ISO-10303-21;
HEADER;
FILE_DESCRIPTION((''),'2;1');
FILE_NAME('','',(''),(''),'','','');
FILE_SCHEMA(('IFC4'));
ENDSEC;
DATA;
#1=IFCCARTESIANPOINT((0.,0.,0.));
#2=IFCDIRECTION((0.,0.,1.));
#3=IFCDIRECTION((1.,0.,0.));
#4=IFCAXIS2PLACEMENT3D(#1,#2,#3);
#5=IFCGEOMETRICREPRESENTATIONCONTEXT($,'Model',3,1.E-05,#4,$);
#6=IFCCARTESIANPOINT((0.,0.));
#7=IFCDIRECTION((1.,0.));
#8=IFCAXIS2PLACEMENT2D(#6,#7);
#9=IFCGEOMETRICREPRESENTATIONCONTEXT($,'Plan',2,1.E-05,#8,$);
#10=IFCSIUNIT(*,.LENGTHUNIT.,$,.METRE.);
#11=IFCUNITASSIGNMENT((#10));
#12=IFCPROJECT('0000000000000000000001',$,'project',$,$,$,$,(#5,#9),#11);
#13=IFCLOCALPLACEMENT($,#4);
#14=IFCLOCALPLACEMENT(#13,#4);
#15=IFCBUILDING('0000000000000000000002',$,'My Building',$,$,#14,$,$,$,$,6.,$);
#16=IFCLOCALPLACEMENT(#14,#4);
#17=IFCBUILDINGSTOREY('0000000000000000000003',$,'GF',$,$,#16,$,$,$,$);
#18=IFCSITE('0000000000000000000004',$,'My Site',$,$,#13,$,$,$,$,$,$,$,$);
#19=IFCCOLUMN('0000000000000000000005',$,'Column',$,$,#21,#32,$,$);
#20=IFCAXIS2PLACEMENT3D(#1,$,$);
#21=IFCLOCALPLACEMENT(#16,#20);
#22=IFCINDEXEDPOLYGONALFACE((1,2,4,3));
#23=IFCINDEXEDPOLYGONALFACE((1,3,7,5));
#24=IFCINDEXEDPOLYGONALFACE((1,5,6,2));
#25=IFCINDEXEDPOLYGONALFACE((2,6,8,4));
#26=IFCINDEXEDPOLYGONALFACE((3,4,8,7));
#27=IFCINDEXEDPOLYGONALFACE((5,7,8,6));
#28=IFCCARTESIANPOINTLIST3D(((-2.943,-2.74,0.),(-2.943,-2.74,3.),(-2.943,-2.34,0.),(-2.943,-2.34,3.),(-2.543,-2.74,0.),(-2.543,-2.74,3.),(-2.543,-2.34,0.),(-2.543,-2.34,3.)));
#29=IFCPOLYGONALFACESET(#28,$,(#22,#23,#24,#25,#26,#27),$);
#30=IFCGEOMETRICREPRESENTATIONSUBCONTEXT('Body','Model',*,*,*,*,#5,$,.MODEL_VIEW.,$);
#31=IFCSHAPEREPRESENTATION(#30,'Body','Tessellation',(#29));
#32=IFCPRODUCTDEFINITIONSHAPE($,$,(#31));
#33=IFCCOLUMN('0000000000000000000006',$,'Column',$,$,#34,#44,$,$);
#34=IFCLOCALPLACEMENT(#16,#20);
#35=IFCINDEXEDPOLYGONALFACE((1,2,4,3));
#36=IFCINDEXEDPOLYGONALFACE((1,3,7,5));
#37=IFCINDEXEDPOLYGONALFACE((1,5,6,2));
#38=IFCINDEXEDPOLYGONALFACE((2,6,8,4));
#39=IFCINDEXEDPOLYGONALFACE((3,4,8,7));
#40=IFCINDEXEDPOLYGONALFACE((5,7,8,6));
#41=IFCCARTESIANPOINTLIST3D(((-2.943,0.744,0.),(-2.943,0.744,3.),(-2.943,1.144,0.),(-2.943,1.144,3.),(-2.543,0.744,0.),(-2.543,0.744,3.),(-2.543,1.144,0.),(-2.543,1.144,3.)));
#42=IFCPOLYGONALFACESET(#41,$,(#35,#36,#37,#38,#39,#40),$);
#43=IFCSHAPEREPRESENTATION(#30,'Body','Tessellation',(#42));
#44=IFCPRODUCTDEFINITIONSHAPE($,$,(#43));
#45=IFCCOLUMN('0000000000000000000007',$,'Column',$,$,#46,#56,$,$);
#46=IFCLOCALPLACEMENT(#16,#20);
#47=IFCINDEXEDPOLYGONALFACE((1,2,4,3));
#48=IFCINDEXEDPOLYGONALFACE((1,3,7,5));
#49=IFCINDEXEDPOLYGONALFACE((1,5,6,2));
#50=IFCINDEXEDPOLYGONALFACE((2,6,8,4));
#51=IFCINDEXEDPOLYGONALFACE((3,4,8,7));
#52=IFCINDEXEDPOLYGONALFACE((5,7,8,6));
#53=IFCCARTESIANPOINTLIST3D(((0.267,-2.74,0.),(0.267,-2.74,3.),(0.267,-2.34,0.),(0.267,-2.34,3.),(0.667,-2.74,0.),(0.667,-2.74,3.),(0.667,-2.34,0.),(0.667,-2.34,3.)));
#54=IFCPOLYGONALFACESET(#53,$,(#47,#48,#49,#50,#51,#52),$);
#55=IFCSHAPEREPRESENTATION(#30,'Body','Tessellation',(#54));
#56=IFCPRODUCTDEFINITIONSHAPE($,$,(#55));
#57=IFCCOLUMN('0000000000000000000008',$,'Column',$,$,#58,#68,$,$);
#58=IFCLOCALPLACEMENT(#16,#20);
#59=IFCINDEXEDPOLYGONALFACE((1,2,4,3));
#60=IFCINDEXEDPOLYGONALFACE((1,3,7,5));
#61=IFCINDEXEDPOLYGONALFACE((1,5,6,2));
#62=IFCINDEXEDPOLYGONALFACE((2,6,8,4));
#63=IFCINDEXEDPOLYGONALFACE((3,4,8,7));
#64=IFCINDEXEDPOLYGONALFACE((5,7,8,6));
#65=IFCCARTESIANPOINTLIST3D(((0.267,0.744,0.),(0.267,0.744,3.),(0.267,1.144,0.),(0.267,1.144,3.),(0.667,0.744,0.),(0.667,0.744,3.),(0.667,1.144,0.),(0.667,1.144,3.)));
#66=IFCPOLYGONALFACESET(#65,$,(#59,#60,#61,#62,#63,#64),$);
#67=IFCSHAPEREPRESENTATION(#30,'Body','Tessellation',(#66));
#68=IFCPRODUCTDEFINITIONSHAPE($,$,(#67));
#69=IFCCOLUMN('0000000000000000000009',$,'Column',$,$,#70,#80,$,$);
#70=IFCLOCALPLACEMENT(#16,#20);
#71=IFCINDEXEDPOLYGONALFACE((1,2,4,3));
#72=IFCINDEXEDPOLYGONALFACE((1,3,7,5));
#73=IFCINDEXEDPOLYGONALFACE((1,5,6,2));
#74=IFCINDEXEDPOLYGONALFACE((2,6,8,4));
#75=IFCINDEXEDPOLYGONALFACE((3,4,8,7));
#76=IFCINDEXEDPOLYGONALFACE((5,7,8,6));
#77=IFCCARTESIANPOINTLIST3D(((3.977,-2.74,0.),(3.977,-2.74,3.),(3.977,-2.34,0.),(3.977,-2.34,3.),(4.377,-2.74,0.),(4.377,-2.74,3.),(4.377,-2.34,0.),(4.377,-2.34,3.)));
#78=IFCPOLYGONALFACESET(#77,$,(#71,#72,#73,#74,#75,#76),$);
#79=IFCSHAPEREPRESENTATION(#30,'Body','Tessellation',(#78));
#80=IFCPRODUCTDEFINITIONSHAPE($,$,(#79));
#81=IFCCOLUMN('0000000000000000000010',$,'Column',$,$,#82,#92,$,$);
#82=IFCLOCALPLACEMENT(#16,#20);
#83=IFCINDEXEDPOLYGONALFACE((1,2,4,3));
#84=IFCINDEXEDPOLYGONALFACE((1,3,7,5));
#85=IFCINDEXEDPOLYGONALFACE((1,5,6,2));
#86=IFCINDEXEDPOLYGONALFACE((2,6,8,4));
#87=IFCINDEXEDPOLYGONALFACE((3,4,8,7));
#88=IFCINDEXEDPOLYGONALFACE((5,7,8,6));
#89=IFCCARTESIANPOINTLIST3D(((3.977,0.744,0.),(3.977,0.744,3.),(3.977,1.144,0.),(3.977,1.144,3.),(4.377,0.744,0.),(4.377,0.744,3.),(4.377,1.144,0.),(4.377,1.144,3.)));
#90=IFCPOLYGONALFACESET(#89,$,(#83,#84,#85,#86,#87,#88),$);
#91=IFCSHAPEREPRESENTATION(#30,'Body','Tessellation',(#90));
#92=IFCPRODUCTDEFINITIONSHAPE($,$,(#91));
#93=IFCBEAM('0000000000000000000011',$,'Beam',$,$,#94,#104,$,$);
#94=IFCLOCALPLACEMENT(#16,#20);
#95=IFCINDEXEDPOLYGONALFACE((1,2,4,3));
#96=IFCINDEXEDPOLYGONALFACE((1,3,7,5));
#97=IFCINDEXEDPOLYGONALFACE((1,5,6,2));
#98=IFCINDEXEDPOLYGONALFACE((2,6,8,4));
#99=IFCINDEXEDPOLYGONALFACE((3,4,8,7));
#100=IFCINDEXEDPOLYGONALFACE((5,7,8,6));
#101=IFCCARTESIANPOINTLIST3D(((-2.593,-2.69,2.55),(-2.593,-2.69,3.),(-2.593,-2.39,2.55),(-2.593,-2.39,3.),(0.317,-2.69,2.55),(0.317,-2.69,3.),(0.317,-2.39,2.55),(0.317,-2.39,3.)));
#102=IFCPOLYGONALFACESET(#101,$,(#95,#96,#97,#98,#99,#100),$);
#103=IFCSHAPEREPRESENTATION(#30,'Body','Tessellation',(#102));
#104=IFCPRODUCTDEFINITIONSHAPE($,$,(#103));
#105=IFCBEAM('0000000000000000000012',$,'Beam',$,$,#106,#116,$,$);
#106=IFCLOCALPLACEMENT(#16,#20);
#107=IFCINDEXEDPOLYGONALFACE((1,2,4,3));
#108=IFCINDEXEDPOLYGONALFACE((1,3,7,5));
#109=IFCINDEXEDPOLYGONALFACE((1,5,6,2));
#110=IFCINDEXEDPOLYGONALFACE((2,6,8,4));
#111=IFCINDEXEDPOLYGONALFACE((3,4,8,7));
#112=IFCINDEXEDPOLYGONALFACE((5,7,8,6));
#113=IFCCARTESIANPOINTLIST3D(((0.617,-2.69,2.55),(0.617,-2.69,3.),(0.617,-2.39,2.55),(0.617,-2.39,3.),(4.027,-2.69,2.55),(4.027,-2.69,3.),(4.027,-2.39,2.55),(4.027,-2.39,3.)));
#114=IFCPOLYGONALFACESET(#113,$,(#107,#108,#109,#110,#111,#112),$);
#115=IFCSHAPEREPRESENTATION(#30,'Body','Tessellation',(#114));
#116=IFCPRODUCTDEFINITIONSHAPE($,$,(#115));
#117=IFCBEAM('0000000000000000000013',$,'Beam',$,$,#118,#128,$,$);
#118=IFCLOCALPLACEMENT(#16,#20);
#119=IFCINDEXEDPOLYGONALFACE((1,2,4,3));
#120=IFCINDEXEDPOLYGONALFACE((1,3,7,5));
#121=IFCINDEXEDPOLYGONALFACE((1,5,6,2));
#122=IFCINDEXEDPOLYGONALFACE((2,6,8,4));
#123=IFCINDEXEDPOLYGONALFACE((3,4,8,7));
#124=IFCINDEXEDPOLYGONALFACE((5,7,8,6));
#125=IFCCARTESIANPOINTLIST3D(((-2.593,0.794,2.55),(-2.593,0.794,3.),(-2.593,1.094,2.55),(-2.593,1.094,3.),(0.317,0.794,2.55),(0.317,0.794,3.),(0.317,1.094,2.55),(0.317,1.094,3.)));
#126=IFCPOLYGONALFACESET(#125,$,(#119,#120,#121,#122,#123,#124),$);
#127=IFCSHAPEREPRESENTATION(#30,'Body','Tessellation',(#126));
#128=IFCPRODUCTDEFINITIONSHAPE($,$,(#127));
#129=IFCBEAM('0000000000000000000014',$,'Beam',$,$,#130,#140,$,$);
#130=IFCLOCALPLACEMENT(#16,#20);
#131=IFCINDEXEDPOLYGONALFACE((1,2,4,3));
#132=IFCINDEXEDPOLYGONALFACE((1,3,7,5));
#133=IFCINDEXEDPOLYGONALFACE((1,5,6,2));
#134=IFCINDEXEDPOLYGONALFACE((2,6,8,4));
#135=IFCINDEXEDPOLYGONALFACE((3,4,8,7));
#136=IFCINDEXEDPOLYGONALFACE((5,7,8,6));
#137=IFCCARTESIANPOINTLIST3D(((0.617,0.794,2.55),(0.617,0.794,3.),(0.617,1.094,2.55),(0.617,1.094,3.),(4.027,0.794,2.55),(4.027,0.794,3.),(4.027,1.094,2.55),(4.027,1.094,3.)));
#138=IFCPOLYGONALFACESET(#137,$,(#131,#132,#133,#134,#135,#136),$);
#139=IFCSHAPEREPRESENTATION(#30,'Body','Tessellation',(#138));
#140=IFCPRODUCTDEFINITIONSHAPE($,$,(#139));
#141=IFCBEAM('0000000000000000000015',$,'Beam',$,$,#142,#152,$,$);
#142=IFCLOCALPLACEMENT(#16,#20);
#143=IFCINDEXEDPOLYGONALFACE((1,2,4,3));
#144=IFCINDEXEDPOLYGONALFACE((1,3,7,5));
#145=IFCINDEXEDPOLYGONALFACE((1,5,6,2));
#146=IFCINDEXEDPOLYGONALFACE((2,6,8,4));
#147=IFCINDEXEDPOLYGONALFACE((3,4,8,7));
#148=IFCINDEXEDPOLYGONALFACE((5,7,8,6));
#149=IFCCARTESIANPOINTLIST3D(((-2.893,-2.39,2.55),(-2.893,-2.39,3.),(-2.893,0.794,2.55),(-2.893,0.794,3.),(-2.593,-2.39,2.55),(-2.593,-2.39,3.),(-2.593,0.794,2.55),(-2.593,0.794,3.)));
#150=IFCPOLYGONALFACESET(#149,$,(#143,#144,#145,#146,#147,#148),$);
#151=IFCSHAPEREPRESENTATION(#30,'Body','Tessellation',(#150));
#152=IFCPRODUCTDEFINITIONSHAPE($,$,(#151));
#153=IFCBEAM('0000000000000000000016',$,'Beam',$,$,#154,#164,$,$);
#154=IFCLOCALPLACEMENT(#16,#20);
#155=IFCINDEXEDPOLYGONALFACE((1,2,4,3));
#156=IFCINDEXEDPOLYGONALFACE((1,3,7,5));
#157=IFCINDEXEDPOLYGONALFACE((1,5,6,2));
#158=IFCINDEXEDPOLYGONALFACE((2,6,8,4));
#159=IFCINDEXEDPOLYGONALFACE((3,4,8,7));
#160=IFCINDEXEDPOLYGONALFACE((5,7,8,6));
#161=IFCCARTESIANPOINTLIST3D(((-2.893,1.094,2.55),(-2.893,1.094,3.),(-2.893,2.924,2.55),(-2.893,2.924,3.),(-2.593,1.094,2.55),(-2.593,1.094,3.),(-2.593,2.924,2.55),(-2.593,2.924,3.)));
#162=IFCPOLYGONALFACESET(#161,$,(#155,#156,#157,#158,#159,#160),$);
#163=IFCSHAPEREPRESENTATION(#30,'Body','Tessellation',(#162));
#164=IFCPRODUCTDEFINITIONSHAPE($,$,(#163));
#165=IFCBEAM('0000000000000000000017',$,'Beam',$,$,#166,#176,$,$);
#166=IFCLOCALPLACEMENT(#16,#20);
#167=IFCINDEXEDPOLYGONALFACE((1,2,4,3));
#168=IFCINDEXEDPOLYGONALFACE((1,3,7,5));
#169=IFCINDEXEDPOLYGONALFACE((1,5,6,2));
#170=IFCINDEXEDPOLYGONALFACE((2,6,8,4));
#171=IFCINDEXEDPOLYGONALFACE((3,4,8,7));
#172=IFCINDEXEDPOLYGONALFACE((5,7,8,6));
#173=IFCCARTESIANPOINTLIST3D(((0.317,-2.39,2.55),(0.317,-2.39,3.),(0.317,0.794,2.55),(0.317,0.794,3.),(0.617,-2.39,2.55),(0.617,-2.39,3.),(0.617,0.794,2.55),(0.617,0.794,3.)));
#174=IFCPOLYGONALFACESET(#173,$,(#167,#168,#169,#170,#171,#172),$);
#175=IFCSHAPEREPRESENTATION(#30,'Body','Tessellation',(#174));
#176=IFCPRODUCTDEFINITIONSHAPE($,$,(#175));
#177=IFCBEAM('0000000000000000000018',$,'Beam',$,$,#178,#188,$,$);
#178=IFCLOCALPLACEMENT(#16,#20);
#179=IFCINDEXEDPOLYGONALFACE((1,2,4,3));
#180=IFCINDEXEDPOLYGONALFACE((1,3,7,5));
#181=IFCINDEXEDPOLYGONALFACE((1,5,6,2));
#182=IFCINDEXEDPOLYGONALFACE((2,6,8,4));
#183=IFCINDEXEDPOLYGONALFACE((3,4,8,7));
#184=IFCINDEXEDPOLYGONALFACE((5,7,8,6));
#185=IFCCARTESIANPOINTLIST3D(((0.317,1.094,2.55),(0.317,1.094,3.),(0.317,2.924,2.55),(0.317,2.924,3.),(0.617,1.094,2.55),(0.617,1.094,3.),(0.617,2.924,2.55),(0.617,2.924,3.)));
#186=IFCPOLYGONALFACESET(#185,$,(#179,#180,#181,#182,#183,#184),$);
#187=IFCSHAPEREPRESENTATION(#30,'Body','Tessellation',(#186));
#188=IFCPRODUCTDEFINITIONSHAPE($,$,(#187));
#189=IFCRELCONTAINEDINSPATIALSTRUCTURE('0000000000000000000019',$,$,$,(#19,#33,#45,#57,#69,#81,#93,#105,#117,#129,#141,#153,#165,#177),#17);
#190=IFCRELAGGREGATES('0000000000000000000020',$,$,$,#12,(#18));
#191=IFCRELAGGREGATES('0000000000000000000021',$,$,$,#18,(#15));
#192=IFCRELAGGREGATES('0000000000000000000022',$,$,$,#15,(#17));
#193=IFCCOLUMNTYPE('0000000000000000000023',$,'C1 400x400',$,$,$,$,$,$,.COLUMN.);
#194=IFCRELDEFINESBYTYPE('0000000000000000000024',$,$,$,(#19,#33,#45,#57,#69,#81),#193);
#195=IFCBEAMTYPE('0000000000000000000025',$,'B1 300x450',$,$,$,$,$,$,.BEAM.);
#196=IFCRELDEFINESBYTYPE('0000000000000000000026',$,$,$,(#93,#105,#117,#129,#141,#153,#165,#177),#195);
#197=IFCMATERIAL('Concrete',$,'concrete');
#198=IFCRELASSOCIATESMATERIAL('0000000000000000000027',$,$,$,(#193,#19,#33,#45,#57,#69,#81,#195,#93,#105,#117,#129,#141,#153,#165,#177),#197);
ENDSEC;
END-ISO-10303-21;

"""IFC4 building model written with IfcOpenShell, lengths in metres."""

from ifc_helpers import new_model, si_unit, frame, origin_with_axes, origin_2d_with_axis, place, context, subcontext, project, spatial, rectangle, extrude, material, material_profile, profile_set, profile_usage, type_object, element, save


model = new_model("IFC4")

# Units and contexts
model_context = context("Model", 3, precision=1e-05, world=origin_with_axes())
plan_context = context("Plan", 2, precision=1e-05, world=origin_2d_with_axis())
body_context_1 = subcontext(model_context, "Body", "Model", "MODEL_VIEW")
ifc_project = project(units=[si_unit("LENGTHUNIT", "METRE")], contexts=[model_context, plan_context])

# Site, building, storey
site_placement = place(None, origin_with_axes())
site = spatial("IfcSite", under=ifc_project, at=site_placement, Name="My Site")
building_placement = place(site_placement, origin_with_axes())
building = spatial("IfcBuilding", under=site, at=building_placement, Name="My Building", ElevationOfTerrain=6.0)
storey_placement = place(building_placement, origin_with_axes())
storey = spatial("IfcBuildingStorey", under=building, at=storey_placement, Name="GF")

# Columns
ifc_material_1 = material(Name="Concrete", Category="concrete")
ifc_material_profile_1 = material_profile(ifc_material_1, rectangle(XDim=0.4, YDim=0.4))
ifc_profile_set_1 = profile_set([ifc_material_profile_1], Name="C1 400x400")
ifc_profile_usage_1 = profile_usage(ifc_profile_set_1, cardinal=5)
column_type = type_object("IfcColumnType", Name="C1 400x400", PredefinedType="COLUMN", material=ifc_profile_set_1)
column_1_placement = place(storey_placement, frame((-2.743, -2.54, 0.0), z_axis=(0.0, 0.0, 1.0), x_axis=(1.0, 0.0, 0.0)))
element("IfcColumn", 1, at=column_1_placement, inside=storey, type_object=column_type, material=ifc_profile_usage_1, Name="Column", context=body_context_1, shape_type="SweptSolid", body=[
    extrude(rectangle(XDim=0.4, YDim=0.4), origin_with_axes(), (0.0, 0.0, 1.0), 3.0),
])
ifc_profile_usage_2 = profile_usage(ifc_profile_set_1, cardinal=5)
column_2_placement = place(storey_placement, frame((-2.743, 0.944, 0.0), z_axis=(0.0, 0.0, 1.0), x_axis=(1.0, 0.0, 0.0)))
element("IfcColumn", 2, at=column_2_placement, inside=storey, type_object=column_type, material=ifc_profile_usage_2, Name="Column", context=body_context_1, shape_type="SweptSolid", body=[
    extrude(rectangle(XDim=0.4, YDim=0.4), origin_with_axes(), (0.0, 0.0, 1.0), 3.0),
])
ifc_profile_usage_3 = profile_usage(ifc_profile_set_1, cardinal=5)
column_3_placement = place(storey_placement, frame((0.467, -2.54, 0.0), z_axis=(0.0, 0.0, 1.0), x_axis=(1.0, 0.0, 0.0)))
element("IfcColumn", 3, at=column_3_placement, inside=storey, type_object=column_type, material=ifc_profile_usage_3, Name="Column", context=body_context_1, shape_type="SweptSolid", body=[
    extrude(rectangle(XDim=0.4, YDim=0.4), origin_with_axes(), (0.0, 0.0, 1.0), 3.0),
])
ifc_profile_usage_4 = profile_usage(ifc_profile_set_1, cardinal=5)
column_4_placement = place(storey_placement, frame((0.467, 0.944, 0.0), z_axis=(0.0, 0.0, 1.0), x_axis=(1.0, 0.0, 0.0)))
element("IfcColumn", 4, at=column_4_placement, inside=storey, type_object=column_type, material=ifc_profile_usage_4, Name="Column", context=body_context_1, shape_type="SweptSolid", body=[
    extrude(rectangle(XDim=0.4, YDim=0.4), origin_with_axes(), (0.0, 0.0, 1.0), 3.0),
])
ifc_profile_usage_5 = profile_usage(ifc_profile_set_1, cardinal=5)
column_5_placement = place(storey_placement, frame((4.177, -2.54, 0.0), z_axis=(0.0, 0.0, 1.0), x_axis=(1.0, 0.0, 0.0)))
element("IfcColumn", 5, at=column_5_placement, inside=storey, type_object=column_type, material=ifc_profile_usage_5, Name="Column", context=body_context_1, shape_type="SweptSolid", body=[
    extrude(rectangle(XDim=0.4, YDim=0.4), origin_with_axes(), (0.0, 0.0, 1.0), 3.0),
])
ifc_profile_usage_6 = profile_usage(ifc_profile_set_1, cardinal=5)
column_6_placement = place(storey_placement, frame((4.177, 0.944, 0.0), z_axis=(0.0, 0.0, 1.0), x_axis=(1.0, 0.0, 0.0)))
element("IfcColumn", 6, at=column_6_placement, inside=storey, type_object=column_type, material=ifc_profile_usage_6, Name="Column", context=body_context_1, shape_type="SweptSolid", body=[
    extrude(rectangle(XDim=0.4, YDim=0.4), origin_with_axes(), (0.0, 0.0, 1.0), 3.0),
])

# Beams
ifc_material_profile_2 = material_profile(ifc_material_1, rectangle(XDim=0.3, YDim=0.45))
ifc_profile_set_2 = profile_set([ifc_material_profile_2], Name="B1 300x450")
ifc_profile_usage_7 = profile_usage(ifc_profile_set_2, cardinal=8)
beam_type = type_object("IfcBeamType", Name="B1 300x450", PredefinedType="BEAM", material=ifc_profile_set_2)
beam_1_placement = place(storey_placement, frame((-2.593, -2.54, 2.975), z_axis=(1.0, 0.0, 0.0), x_axis=(0.0, 1.0, 0.0)))
element("IfcBeam", 7, at=beam_1_placement, inside=storey, type_object=beam_type, material=ifc_profile_usage_7, Name="Beam", context=body_context_1, shape_type="SweptSolid", body=[
    extrude(rectangle(XDim=0.3, YDim=0.45), frame((0.0, -0.2, 0.0), z_axis=(0.0, 0.0, 1.0), x_axis=(1.0, 0.0, 0.0)), (0.0, 0.0, 1.0), 2.91),
])
ifc_profile_usage_8 = profile_usage(ifc_profile_set_2, cardinal=8)
beam_2_placement = place(storey_placement, frame((0.617, -2.54, 2.975), z_axis=(1.0, 0.0, 0.0), x_axis=(0.0, 1.0, 0.0)))
element("IfcBeam", 8, at=beam_2_placement, inside=storey, type_object=beam_type, material=ifc_profile_usage_8, Name="Beam", context=body_context_1, shape_type="SweptSolid", body=[
    extrude(rectangle(XDim=0.3, YDim=0.45), frame((0.0, -0.2, 0.0), z_axis=(0.0, 0.0, 1.0), x_axis=(1.0, 0.0, 0.0)), (0.0, 0.0, 1.0), 3.41),
])
ifc_profile_usage_9 = profile_usage(ifc_profile_set_2, cardinal=8)
beam_3_placement = place(storey_placement, frame((-2.593, 0.944, 2.975), z_axis=(1.0, 0.0, 0.0), x_axis=(0.0, 1.0, 0.0)))
element("IfcBeam", 9, at=beam_3_placement, inside=storey, type_object=beam_type, material=ifc_profile_usage_9, Name="Beam", context=body_context_1, shape_type="SweptSolid", body=[
    extrude(rectangle(XDim=0.3, YDim=0.45), frame((0.0, -0.2, 0.0), z_axis=(0.0, 0.0, 1.0), x_axis=(1.0, 0.0, 0.0)), (0.0, 0.0, 1.0), 2.91),
])
ifc_profile_usage_10 = profile_usage(ifc_profile_set_2, cardinal=8)
beam_4_placement = place(storey_placement, frame((0.617, 0.944, 2.975), z_axis=(1.0, 0.0, 0.0), x_axis=(0.0, 1.0, 0.0)))
element("IfcBeam", 10, at=beam_4_placement, inside=storey, type_object=beam_type, material=ifc_profile_usage_10, Name="Beam", context=body_context_1, shape_type="SweptSolid", body=[
    extrude(rectangle(XDim=0.3, YDim=0.45), frame((0.0, -0.2, 0.0), z_axis=(0.0, 0.0, 1.0), x_axis=(1.0, 0.0, 0.0)), (0.0, 0.0, 1.0), 3.41),
])
ifc_profile_usage_11 = profile_usage(ifc_profile_set_2, cardinal=8)
beam_5_placement = place(storey_placement, frame((-2.743, -2.39, 2.975), z_axis=(0.0, 1.0, 0.0), x_axis=(-1.0, 0.0, 0.0)))
element("IfcBeam", 11, at=beam_5_placement, inside=storey, type_object=beam_type, material=ifc_profile_usage_11, Name="Beam", context=body_context_1, shape_type="SweptSolid", body=[
    extrude(rectangle(XDim=0.3, YDim=0.45), frame((0.0, -0.2, 0.0), z_axis=(0.0, 0.0, 1.0), x_axis=(1.0, 0.0, 0.0)), (0.0, 0.0, 1.0), 3.184),
])
ifc_profile_usage_12 = profile_usage(ifc_profile_set_2, cardinal=8)
beam_6_placement = place(storey_placement, frame((-2.743, 1.094, 2.975), z_axis=(0.0, 1.0, 0.0), x_axis=(-1.0, 0.0, 0.0)))
element("IfcBeam", 12, at=beam_6_placement, inside=storey, type_object=beam_type, material=ifc_profile_usage_12, Name="Beam", context=body_context_1, shape_type="SweptSolid", body=[
    extrude(rectangle(XDim=0.3, YDim=0.45), frame((0.0, -0.2, 0.0), z_axis=(0.0, 0.0, 1.0), x_axis=(1.0, 0.0, 0.0)), (0.0, 0.0, 1.0), 1.83),
])
ifc_profile_usage_13 = profile_usage(ifc_profile_set_2, cardinal=8)
beam_7_placement = place(storey_placement, frame((0.467, -2.39, 2.975), z_axis=(0.0, 1.0, 0.0), x_axis=(-1.0, 0.0, 0.0)))
element("IfcBeam", 13, at=beam_7_placement, inside=storey, type_object=beam_type, material=ifc_profile_usage_13, Name="Beam", context=body_context_1, shape_type="SweptSolid", body=[
    extrude(rectangle(XDim=0.3, YDim=0.45), frame((0.0, -0.2, 0.0), z_axis=(0.0, 0.0, 1.0), x_axis=(1.0, 0.0, 0.0)), (0.0, 0.0, 1.0), 3.184),
])
ifc_profile_usage_14 = profile_usage(ifc_profile_set_2, cardinal=8)
beam_8_placement = place(storey_placement, frame((0.467, 1.094, 2.975), z_axis=(0.0, 1.0, 0.0), x_axis=(-1.0, 0.0, 0.0)))
element("IfcBeam", 14, at=beam_8_placement, inside=storey, type_object=beam_type, material=ifc_profile_usage_14, Name="Beam", context=body_context_1, shape_type="SweptSolid", body=[
    extrude(rectangle(XDim=0.3, YDim=0.45), frame((0.0, -0.2, 0.0), z_axis=(0.0, 0.0, 1.0), x_axis=(1.0, 0.0, 0.0)), (0.0, 0.0, 1.0), 1.83),
])

save(model, "model.ifc")
